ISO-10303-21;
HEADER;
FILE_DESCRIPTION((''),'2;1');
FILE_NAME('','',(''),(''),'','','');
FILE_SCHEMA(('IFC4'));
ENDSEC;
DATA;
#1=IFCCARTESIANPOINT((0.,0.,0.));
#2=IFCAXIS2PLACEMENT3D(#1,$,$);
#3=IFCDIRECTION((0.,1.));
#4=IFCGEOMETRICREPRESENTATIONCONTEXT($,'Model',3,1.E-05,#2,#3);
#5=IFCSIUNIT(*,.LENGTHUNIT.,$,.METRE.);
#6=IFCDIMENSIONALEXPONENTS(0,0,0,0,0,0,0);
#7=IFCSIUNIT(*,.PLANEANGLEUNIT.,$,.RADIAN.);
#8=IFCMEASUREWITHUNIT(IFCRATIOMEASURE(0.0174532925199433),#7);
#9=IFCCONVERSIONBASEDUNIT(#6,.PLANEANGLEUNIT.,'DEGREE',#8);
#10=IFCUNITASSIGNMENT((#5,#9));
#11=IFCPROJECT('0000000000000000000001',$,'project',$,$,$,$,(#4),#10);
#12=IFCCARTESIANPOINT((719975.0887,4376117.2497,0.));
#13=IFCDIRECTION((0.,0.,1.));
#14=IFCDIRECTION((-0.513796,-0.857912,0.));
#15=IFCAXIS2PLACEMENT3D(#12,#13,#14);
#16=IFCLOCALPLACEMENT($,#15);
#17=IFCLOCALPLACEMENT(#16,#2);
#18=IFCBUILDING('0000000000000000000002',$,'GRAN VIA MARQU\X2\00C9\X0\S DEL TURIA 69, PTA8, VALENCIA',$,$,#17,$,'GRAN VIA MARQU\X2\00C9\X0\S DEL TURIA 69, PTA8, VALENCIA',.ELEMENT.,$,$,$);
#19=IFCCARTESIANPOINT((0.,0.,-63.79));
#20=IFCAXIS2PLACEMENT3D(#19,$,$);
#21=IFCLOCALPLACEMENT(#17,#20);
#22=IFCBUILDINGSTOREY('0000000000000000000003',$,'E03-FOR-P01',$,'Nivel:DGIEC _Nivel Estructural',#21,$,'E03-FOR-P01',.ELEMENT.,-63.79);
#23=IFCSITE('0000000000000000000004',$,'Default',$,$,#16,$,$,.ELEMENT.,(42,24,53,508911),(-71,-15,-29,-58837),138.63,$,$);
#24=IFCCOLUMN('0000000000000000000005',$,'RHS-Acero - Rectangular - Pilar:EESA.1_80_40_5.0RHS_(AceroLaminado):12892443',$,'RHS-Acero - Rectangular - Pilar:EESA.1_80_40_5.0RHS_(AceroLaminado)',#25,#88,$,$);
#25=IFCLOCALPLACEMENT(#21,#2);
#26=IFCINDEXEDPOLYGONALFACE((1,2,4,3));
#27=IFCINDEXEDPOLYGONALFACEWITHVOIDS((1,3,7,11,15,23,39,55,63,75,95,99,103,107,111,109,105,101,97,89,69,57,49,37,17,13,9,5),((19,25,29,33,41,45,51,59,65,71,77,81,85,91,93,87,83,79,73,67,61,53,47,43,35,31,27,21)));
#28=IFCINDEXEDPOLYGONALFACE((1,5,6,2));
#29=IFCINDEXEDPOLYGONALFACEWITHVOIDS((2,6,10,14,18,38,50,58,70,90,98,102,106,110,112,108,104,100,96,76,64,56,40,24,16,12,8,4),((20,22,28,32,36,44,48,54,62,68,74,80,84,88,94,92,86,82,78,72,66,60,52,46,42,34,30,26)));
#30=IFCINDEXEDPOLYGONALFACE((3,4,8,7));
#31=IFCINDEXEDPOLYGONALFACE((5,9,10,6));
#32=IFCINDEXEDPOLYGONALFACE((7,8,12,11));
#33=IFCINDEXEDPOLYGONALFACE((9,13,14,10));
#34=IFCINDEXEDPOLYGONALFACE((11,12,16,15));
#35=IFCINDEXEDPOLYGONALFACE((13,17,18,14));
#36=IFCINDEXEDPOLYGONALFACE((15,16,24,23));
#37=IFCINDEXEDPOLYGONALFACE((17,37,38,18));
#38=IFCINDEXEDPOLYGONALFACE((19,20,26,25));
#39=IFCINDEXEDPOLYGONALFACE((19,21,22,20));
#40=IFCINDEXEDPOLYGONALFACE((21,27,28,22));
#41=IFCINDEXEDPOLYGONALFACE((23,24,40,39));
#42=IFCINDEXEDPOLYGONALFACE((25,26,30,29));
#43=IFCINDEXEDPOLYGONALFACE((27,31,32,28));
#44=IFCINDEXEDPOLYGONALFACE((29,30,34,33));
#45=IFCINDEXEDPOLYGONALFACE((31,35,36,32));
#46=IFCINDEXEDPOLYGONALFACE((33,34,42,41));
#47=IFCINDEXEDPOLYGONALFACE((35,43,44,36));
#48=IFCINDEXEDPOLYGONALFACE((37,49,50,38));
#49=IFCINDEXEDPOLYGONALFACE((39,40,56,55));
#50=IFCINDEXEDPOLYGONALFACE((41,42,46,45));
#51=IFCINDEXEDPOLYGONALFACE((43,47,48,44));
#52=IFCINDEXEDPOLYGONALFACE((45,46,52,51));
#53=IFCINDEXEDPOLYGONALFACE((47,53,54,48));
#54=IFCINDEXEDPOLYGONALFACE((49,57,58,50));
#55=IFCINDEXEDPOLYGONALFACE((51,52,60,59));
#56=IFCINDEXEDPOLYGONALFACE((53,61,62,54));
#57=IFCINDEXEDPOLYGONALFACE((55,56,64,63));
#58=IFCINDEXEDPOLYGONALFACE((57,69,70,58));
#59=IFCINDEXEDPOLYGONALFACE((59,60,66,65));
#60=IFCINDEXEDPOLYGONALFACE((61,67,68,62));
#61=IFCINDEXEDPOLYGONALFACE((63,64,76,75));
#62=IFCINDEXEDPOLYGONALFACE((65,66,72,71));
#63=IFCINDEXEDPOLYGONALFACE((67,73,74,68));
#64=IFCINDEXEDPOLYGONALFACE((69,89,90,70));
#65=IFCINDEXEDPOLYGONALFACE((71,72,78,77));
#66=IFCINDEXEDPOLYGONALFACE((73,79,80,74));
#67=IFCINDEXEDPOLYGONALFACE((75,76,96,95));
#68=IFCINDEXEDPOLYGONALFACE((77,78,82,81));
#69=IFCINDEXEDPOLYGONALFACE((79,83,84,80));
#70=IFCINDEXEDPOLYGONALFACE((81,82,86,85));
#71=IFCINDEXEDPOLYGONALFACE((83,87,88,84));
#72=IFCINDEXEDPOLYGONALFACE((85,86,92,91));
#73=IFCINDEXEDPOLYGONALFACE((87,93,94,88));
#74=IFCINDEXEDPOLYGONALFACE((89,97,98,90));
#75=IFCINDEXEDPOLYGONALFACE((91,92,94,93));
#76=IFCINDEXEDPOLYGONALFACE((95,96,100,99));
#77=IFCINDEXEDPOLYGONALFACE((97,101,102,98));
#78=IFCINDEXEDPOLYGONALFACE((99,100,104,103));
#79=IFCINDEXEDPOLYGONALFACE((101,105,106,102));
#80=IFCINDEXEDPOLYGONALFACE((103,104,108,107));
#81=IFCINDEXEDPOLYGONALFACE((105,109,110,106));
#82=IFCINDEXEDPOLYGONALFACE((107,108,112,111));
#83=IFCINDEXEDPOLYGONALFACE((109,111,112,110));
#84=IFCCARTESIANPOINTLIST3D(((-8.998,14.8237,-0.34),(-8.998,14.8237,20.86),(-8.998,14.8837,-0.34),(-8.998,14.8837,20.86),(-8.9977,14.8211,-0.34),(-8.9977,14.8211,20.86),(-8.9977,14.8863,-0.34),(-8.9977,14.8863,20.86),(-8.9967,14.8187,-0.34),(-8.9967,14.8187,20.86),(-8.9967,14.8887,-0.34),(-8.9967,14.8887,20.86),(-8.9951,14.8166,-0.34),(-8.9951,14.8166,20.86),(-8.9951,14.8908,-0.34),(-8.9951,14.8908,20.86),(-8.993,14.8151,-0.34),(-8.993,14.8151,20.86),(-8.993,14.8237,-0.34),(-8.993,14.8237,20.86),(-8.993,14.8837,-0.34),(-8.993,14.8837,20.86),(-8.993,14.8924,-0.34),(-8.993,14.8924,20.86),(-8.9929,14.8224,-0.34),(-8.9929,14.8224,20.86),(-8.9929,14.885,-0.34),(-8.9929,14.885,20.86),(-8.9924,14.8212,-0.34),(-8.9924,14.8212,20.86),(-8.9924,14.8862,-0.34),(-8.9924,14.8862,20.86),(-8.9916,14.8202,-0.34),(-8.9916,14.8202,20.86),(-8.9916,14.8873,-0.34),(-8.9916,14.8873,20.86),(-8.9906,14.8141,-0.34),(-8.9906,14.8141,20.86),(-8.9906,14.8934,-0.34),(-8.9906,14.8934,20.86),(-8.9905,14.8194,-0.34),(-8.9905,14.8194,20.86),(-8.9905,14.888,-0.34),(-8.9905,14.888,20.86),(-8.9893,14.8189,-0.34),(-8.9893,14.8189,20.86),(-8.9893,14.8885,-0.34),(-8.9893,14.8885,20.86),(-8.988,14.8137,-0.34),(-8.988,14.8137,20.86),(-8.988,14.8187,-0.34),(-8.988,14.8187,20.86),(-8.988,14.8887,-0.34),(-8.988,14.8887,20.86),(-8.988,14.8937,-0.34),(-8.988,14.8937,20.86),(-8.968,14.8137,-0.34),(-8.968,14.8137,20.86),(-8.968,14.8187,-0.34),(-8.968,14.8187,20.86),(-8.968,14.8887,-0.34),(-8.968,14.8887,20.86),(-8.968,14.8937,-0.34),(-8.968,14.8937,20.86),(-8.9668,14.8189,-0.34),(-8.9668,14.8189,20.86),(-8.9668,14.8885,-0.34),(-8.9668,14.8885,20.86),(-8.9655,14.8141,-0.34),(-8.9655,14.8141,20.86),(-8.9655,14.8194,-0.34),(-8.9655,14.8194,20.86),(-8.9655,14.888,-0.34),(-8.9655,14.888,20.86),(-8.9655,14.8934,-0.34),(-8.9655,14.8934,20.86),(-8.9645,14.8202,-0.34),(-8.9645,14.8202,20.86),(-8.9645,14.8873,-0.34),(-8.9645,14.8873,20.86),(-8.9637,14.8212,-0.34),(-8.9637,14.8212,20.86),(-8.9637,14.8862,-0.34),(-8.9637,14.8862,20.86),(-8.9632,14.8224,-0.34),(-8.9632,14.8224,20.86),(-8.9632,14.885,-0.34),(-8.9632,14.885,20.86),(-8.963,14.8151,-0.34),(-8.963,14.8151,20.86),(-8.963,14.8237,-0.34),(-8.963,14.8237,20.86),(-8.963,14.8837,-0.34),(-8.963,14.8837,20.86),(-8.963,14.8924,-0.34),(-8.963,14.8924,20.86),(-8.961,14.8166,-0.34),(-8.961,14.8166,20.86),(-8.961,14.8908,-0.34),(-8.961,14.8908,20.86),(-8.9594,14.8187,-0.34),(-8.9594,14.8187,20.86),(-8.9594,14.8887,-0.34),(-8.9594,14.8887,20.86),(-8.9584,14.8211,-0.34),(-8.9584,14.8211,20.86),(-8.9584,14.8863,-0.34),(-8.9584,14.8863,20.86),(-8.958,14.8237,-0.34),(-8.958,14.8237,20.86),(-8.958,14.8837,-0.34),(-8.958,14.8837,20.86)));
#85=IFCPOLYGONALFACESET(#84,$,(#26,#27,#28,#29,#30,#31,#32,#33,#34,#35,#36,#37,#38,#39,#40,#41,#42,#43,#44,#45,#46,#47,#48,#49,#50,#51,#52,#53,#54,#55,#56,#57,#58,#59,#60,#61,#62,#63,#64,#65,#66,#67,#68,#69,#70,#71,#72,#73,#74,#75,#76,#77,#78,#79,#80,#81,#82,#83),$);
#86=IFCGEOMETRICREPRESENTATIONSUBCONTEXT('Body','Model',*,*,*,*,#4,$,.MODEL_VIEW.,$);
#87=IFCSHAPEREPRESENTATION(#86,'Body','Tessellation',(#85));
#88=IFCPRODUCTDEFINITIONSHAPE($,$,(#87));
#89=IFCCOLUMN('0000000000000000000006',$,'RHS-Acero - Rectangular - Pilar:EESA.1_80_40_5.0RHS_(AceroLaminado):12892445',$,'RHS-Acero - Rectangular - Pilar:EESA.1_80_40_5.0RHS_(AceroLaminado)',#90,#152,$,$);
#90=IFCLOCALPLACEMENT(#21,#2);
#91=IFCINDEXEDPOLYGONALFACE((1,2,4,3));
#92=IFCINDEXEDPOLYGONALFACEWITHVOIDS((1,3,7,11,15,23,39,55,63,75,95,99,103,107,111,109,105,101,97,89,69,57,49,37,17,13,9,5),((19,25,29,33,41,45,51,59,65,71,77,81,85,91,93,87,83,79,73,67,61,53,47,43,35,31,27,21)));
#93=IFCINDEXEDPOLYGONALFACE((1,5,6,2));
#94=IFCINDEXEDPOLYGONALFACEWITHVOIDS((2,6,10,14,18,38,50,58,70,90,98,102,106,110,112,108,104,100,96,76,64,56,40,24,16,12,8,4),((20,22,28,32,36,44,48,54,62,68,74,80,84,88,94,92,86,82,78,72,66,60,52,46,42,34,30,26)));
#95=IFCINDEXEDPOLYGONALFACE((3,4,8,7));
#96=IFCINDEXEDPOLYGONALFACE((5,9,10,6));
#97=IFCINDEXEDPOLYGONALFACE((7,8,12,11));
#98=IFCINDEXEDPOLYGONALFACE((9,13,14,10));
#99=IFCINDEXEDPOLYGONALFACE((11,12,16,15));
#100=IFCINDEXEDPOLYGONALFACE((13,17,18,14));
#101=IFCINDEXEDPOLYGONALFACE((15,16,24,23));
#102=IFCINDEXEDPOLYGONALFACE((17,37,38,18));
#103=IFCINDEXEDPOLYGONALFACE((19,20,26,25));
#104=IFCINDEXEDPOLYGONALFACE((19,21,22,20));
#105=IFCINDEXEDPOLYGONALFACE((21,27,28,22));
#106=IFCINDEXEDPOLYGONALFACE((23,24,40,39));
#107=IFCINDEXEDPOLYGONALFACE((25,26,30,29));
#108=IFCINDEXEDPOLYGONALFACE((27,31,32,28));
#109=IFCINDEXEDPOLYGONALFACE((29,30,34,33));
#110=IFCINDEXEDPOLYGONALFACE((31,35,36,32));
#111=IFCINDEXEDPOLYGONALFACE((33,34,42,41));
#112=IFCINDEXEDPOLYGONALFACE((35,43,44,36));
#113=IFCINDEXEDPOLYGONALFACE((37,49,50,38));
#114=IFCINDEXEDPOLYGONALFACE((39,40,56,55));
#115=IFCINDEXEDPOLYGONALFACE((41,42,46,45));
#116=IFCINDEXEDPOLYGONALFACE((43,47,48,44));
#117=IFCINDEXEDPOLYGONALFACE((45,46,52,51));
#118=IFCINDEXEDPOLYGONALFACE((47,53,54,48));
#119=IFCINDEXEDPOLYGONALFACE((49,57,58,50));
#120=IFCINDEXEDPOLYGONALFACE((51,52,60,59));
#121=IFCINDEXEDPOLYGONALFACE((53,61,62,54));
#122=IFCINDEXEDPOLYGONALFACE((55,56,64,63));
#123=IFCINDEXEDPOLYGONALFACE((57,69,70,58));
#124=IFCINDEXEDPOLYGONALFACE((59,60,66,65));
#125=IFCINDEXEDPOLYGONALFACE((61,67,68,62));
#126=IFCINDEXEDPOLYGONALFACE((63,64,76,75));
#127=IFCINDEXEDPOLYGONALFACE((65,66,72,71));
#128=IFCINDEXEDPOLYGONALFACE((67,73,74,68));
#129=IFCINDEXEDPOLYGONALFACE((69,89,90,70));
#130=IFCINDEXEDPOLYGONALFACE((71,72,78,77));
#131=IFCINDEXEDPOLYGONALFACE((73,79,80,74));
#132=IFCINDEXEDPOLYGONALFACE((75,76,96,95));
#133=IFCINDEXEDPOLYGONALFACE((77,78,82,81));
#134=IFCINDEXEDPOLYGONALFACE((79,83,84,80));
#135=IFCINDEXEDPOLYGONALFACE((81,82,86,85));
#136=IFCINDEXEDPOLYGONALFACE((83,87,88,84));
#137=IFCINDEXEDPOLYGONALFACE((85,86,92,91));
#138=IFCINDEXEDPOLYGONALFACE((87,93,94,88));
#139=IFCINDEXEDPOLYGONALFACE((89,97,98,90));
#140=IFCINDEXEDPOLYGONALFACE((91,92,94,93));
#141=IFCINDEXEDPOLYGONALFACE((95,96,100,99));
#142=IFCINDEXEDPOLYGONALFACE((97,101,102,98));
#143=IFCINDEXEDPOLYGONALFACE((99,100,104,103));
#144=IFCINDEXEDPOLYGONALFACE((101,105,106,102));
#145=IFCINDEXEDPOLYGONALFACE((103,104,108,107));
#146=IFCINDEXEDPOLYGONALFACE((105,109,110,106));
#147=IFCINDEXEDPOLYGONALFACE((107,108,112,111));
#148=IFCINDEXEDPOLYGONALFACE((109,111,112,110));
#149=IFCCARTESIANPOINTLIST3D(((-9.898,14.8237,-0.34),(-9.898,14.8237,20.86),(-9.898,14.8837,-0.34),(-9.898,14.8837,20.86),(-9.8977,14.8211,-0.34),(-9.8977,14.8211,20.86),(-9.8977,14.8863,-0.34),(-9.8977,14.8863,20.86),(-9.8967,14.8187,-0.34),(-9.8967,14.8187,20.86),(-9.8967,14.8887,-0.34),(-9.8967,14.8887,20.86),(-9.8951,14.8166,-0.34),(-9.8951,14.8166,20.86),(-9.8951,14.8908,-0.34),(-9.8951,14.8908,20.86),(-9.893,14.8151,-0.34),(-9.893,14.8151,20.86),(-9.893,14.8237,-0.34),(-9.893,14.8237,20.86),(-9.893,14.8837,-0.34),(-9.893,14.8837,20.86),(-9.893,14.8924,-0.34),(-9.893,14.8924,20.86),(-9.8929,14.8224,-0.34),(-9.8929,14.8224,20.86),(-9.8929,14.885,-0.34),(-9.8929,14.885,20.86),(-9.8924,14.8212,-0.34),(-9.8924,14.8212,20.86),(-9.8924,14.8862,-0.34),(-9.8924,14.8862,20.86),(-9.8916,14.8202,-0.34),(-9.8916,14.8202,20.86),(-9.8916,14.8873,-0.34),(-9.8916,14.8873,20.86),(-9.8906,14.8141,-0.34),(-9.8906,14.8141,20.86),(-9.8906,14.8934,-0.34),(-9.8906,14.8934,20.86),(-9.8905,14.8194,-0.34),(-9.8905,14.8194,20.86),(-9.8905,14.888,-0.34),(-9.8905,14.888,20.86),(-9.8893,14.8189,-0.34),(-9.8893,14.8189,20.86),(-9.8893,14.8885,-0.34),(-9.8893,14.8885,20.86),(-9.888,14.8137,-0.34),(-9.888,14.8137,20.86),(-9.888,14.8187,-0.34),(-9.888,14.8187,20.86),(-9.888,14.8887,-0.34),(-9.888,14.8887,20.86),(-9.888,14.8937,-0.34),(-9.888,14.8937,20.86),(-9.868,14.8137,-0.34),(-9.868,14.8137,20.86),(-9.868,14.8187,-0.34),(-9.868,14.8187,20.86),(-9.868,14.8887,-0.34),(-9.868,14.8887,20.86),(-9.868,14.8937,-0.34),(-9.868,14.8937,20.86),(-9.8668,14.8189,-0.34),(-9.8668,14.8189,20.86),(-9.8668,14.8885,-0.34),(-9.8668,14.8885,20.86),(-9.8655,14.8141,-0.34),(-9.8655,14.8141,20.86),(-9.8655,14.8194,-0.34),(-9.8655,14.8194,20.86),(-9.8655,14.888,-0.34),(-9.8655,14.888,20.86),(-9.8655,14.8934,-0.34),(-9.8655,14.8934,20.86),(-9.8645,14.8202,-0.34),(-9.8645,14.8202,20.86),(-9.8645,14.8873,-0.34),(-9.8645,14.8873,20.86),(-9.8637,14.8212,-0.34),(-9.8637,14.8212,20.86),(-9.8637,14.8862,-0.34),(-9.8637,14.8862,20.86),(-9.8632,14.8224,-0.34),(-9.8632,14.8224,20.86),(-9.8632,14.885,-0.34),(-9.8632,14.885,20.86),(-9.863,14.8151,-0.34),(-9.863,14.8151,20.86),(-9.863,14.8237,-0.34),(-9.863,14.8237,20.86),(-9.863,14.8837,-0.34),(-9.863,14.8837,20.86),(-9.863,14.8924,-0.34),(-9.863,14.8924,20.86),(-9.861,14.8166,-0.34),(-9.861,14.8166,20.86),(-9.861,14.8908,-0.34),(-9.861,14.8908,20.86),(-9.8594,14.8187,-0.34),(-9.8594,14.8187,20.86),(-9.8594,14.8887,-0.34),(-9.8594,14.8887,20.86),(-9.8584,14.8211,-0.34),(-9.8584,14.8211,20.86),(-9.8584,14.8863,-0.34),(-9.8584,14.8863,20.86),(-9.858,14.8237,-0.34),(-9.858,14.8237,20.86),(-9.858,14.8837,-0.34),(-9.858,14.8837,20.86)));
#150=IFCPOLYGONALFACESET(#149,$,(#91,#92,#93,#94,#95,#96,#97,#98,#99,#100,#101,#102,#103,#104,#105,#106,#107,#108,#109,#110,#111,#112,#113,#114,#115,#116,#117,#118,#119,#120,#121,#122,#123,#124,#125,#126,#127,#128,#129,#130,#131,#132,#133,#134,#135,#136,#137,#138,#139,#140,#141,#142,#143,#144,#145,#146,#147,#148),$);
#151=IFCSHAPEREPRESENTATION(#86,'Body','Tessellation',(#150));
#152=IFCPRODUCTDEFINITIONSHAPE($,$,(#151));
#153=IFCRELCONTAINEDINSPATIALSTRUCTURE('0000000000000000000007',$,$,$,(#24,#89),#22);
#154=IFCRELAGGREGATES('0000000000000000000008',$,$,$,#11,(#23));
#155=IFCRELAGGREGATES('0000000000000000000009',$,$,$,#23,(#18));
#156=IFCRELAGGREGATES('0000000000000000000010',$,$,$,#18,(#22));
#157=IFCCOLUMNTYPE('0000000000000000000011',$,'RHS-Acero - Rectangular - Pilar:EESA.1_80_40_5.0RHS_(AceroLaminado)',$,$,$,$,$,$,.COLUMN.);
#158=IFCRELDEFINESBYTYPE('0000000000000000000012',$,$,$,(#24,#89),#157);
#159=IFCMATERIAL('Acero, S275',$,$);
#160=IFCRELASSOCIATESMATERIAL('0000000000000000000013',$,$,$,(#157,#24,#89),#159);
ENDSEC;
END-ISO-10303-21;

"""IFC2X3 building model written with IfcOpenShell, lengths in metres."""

from ifc_helpers import new_model, entity, si_unit, converted_unit, direction, frame, frame_2d, origin, place, context, subcontext, project, spatial, polyline, circle_curve, parameter, trimmed, segment, composite_curve, outline, extrude, source, transform, mapped, material, type_object, type_shapes, element, save


model = new_model("IFC2X3")

# Units and contexts
model_context = context("Model", 3, precision=1e-05, world=origin(), true_north=direction((0.0, 1.0)))
body_context = subcontext(model_context, "Body", "Model", "MODEL_VIEW")
ifc_project = project(units=[si_unit("LENGTHUNIT", "METRE"), converted_unit("PLANEANGLEUNIT", "DEGREE", entity("IfcRatioMeasure", 0.0174532925199433), si_unit("PLANEANGLEUNIT", "RADIAN"), dimensions=[0, 0, 0, 0, 0, 0, 0])], contexts=[model_context])

# Site, building, storey
site_placement = place(None, frame((719975.0887, 4376117.2497, 0.0), z_axis=(0.0, 0.0, 1.0), x_axis=(-0.513796, -0.857912, 0.0)))
site = spatial("IfcSite", under=ifc_project, at=site_placement, Name="Default", CompositionType="ELEMENT", RefLatitude=(42, 24, 53, 508911), RefLongitude=(-71, -15, -29, -58837), RefElevation=138.63)
building_placement = place(site_placement, origin())
building = spatial("IfcBuilding", under=site, at=building_placement, Name="GRAN VIA MARQUÉS DEL TURIA 69, PTA8, VALENCIA", LongName="GRAN VIA MARQUÉS DEL TURIA 69, PTA8, VALENCIA", CompositionType="ELEMENT")
storey_placement = place(building_placement, frame((0.0, 0.0, -63.79)))
storey = spatial("IfcBuildingStorey", under=building, at=storey_placement, Name="E03-FOR-P01", ObjectType="Nivel:DGIEC _Nivel Estructural", LongName="E03-FOR-P01", CompositionType="ELEMENT", Elevation=-63.79)

# Columns
ifc_material_1 = material(Name="Acero, S275")
column_type_1 = type_object("IfcColumnType", Name="RHS-Acero - Rectangular - Pilar:EESA.1_80_40_5.0RHS_(AceroLaminado)", PredefinedType="COLUMN", material=ifc_material_1)
shared_shape_1 = source(origin(), body_context, "Body", "SweptSolid", [
    extrude(outline(composite_curve([segment(polyline([(-0.01, -0.04), (0.01, -0.04)]), True, "CONTINUOUS"), segment(trimmed(circle_curve(frame_2d((0.01, -0.03), x_axis=(-1.0, 0.0)), 0.01), [parameter(90.0)], [parameter(180.0)], True, "PARAMETER"), True, "CONTINUOUS"), segment(polyline([(0.02, -0.03), (0.02, 0.03)]), True, "CONTINUOUS"), segment(trimmed(circle_curve(frame_2d((0.01, 0.03), x_axis=(-1.0, 0.0)), 0.01), [parameter(180.0)], [parameter(270.0)], True, "PARAMETER"), True, "CONTINUOUS"), segment(polyline([(0.01, 0.04), (-0.01, 0.04)]), True, "CONTINUOUS"), segment(trimmed(circle_curve(frame_2d((-0.01, 0.03), x_axis=(-1.0, 0.0)), 0.01), [parameter(270.0)], [parameter(360.0)], True, "PARAMETER"), True, "CONTINUOUS"), segment(polyline([(-0.02, 0.03), (-0.02, -0.03)]), True, "CONTINUOUS"), segment(trimmed(circle_curve(frame_2d((-0.01, -0.03), x_axis=(-1.0, 0.0)), 0.01), [parameter(360.0)], [parameter(90.0)], True, "PARAMETER"), True, "CONTINUOUS")], self_intersect=False), holes=[composite_curve([segment(trimmed(circle_curve(frame_2d((-0.01, -0.03), x_axis=(-1.0, 0.0)), 0.005), [parameter(0.0)], [parameter(90.0)], True, "PARAMETER"), False, "CONTINUOUS"), segment(polyline([(-0.015, -0.03), (-0.015, 0.03)]), True, "CONTINUOUS"), segment(trimmed(circle_curve(frame_2d((-0.01, 0.03), x_axis=(-1.0, 0.0)), 0.005), [parameter(270.0)], [parameter(0.0)], True, "PARAMETER"), False, "CONTINUOUS"), segment(polyline([(-0.01, 0.035), (0.01, 0.035)]), True, "CONTINUOUS"), segment(trimmed(circle_curve(frame_2d((0.01, 0.03), x_axis=(-1.0, 0.0)), 0.005), [parameter(180.0)], [parameter(270.0)], True, "PARAMETER"), False, "CONTINUOUS"), segment(polyline([(0.015, 0.03), (0.015, -0.03)]), True, "CONTINUOUS"), segment(trimmed(circle_curve(frame_2d((0.01, -0.03), x_axis=(-1.0, 0.0)), 0.005), [parameter(90.0)], [parameter(180.0)], True, "PARAMETER"), False, "CONTINUOUS"), segment(polyline([(0.01, -0.035), (-0.01, -0.035)]), True, "CONTINUOUS")], self_intersect=False)]), frame((0.0, 0.0, -64.13), z_axis=(0.0, 0.0, 1.0), x_axis=(-1.0, 0.0, 0.0)), (0.0, 0.0, 1.0), 21.2),
])
type_shapes(column_type_1, [shared_shape_1])
for number, where, z_axis, x_axis, name in (
    (1, (-8.978, 14.8537, 63.79), (0.0, 0.0, 1.0), (-1.0, 0.0, 0.0), "RHS-Acero - Rectangular - Pilar:EESA.1_80_40_5.0RHS_(AceroLaminado):12892443"),
    (2, (-9.878, 14.8537, 63.79), (0.0, 0.0, 1.0), (-1.0, 0.0, 0.0), "RHS-Acero - Rectangular - Pilar:EESA.1_80_40_5.0RHS_(AceroLaminado):12892445"),
):
    element("IfcColumn", number, at=place(storey_placement, frame(where, z_axis=z_axis, x_axis=x_axis)), inside=storey, type_object=column_type_1, material=ifc_material_1, Name=name, ObjectType="RHS-Acero - Rectangular - Pilar:EESA.1_80_40_5.0RHS_(AceroLaminado)", context=body_context, shape_type="MappedRepresentation", body=[
        mapped(shared_shape_1, transform((0.0, 0.0, 0.0), scale=1.0)),
    ])

save(model, "model.ifc")
